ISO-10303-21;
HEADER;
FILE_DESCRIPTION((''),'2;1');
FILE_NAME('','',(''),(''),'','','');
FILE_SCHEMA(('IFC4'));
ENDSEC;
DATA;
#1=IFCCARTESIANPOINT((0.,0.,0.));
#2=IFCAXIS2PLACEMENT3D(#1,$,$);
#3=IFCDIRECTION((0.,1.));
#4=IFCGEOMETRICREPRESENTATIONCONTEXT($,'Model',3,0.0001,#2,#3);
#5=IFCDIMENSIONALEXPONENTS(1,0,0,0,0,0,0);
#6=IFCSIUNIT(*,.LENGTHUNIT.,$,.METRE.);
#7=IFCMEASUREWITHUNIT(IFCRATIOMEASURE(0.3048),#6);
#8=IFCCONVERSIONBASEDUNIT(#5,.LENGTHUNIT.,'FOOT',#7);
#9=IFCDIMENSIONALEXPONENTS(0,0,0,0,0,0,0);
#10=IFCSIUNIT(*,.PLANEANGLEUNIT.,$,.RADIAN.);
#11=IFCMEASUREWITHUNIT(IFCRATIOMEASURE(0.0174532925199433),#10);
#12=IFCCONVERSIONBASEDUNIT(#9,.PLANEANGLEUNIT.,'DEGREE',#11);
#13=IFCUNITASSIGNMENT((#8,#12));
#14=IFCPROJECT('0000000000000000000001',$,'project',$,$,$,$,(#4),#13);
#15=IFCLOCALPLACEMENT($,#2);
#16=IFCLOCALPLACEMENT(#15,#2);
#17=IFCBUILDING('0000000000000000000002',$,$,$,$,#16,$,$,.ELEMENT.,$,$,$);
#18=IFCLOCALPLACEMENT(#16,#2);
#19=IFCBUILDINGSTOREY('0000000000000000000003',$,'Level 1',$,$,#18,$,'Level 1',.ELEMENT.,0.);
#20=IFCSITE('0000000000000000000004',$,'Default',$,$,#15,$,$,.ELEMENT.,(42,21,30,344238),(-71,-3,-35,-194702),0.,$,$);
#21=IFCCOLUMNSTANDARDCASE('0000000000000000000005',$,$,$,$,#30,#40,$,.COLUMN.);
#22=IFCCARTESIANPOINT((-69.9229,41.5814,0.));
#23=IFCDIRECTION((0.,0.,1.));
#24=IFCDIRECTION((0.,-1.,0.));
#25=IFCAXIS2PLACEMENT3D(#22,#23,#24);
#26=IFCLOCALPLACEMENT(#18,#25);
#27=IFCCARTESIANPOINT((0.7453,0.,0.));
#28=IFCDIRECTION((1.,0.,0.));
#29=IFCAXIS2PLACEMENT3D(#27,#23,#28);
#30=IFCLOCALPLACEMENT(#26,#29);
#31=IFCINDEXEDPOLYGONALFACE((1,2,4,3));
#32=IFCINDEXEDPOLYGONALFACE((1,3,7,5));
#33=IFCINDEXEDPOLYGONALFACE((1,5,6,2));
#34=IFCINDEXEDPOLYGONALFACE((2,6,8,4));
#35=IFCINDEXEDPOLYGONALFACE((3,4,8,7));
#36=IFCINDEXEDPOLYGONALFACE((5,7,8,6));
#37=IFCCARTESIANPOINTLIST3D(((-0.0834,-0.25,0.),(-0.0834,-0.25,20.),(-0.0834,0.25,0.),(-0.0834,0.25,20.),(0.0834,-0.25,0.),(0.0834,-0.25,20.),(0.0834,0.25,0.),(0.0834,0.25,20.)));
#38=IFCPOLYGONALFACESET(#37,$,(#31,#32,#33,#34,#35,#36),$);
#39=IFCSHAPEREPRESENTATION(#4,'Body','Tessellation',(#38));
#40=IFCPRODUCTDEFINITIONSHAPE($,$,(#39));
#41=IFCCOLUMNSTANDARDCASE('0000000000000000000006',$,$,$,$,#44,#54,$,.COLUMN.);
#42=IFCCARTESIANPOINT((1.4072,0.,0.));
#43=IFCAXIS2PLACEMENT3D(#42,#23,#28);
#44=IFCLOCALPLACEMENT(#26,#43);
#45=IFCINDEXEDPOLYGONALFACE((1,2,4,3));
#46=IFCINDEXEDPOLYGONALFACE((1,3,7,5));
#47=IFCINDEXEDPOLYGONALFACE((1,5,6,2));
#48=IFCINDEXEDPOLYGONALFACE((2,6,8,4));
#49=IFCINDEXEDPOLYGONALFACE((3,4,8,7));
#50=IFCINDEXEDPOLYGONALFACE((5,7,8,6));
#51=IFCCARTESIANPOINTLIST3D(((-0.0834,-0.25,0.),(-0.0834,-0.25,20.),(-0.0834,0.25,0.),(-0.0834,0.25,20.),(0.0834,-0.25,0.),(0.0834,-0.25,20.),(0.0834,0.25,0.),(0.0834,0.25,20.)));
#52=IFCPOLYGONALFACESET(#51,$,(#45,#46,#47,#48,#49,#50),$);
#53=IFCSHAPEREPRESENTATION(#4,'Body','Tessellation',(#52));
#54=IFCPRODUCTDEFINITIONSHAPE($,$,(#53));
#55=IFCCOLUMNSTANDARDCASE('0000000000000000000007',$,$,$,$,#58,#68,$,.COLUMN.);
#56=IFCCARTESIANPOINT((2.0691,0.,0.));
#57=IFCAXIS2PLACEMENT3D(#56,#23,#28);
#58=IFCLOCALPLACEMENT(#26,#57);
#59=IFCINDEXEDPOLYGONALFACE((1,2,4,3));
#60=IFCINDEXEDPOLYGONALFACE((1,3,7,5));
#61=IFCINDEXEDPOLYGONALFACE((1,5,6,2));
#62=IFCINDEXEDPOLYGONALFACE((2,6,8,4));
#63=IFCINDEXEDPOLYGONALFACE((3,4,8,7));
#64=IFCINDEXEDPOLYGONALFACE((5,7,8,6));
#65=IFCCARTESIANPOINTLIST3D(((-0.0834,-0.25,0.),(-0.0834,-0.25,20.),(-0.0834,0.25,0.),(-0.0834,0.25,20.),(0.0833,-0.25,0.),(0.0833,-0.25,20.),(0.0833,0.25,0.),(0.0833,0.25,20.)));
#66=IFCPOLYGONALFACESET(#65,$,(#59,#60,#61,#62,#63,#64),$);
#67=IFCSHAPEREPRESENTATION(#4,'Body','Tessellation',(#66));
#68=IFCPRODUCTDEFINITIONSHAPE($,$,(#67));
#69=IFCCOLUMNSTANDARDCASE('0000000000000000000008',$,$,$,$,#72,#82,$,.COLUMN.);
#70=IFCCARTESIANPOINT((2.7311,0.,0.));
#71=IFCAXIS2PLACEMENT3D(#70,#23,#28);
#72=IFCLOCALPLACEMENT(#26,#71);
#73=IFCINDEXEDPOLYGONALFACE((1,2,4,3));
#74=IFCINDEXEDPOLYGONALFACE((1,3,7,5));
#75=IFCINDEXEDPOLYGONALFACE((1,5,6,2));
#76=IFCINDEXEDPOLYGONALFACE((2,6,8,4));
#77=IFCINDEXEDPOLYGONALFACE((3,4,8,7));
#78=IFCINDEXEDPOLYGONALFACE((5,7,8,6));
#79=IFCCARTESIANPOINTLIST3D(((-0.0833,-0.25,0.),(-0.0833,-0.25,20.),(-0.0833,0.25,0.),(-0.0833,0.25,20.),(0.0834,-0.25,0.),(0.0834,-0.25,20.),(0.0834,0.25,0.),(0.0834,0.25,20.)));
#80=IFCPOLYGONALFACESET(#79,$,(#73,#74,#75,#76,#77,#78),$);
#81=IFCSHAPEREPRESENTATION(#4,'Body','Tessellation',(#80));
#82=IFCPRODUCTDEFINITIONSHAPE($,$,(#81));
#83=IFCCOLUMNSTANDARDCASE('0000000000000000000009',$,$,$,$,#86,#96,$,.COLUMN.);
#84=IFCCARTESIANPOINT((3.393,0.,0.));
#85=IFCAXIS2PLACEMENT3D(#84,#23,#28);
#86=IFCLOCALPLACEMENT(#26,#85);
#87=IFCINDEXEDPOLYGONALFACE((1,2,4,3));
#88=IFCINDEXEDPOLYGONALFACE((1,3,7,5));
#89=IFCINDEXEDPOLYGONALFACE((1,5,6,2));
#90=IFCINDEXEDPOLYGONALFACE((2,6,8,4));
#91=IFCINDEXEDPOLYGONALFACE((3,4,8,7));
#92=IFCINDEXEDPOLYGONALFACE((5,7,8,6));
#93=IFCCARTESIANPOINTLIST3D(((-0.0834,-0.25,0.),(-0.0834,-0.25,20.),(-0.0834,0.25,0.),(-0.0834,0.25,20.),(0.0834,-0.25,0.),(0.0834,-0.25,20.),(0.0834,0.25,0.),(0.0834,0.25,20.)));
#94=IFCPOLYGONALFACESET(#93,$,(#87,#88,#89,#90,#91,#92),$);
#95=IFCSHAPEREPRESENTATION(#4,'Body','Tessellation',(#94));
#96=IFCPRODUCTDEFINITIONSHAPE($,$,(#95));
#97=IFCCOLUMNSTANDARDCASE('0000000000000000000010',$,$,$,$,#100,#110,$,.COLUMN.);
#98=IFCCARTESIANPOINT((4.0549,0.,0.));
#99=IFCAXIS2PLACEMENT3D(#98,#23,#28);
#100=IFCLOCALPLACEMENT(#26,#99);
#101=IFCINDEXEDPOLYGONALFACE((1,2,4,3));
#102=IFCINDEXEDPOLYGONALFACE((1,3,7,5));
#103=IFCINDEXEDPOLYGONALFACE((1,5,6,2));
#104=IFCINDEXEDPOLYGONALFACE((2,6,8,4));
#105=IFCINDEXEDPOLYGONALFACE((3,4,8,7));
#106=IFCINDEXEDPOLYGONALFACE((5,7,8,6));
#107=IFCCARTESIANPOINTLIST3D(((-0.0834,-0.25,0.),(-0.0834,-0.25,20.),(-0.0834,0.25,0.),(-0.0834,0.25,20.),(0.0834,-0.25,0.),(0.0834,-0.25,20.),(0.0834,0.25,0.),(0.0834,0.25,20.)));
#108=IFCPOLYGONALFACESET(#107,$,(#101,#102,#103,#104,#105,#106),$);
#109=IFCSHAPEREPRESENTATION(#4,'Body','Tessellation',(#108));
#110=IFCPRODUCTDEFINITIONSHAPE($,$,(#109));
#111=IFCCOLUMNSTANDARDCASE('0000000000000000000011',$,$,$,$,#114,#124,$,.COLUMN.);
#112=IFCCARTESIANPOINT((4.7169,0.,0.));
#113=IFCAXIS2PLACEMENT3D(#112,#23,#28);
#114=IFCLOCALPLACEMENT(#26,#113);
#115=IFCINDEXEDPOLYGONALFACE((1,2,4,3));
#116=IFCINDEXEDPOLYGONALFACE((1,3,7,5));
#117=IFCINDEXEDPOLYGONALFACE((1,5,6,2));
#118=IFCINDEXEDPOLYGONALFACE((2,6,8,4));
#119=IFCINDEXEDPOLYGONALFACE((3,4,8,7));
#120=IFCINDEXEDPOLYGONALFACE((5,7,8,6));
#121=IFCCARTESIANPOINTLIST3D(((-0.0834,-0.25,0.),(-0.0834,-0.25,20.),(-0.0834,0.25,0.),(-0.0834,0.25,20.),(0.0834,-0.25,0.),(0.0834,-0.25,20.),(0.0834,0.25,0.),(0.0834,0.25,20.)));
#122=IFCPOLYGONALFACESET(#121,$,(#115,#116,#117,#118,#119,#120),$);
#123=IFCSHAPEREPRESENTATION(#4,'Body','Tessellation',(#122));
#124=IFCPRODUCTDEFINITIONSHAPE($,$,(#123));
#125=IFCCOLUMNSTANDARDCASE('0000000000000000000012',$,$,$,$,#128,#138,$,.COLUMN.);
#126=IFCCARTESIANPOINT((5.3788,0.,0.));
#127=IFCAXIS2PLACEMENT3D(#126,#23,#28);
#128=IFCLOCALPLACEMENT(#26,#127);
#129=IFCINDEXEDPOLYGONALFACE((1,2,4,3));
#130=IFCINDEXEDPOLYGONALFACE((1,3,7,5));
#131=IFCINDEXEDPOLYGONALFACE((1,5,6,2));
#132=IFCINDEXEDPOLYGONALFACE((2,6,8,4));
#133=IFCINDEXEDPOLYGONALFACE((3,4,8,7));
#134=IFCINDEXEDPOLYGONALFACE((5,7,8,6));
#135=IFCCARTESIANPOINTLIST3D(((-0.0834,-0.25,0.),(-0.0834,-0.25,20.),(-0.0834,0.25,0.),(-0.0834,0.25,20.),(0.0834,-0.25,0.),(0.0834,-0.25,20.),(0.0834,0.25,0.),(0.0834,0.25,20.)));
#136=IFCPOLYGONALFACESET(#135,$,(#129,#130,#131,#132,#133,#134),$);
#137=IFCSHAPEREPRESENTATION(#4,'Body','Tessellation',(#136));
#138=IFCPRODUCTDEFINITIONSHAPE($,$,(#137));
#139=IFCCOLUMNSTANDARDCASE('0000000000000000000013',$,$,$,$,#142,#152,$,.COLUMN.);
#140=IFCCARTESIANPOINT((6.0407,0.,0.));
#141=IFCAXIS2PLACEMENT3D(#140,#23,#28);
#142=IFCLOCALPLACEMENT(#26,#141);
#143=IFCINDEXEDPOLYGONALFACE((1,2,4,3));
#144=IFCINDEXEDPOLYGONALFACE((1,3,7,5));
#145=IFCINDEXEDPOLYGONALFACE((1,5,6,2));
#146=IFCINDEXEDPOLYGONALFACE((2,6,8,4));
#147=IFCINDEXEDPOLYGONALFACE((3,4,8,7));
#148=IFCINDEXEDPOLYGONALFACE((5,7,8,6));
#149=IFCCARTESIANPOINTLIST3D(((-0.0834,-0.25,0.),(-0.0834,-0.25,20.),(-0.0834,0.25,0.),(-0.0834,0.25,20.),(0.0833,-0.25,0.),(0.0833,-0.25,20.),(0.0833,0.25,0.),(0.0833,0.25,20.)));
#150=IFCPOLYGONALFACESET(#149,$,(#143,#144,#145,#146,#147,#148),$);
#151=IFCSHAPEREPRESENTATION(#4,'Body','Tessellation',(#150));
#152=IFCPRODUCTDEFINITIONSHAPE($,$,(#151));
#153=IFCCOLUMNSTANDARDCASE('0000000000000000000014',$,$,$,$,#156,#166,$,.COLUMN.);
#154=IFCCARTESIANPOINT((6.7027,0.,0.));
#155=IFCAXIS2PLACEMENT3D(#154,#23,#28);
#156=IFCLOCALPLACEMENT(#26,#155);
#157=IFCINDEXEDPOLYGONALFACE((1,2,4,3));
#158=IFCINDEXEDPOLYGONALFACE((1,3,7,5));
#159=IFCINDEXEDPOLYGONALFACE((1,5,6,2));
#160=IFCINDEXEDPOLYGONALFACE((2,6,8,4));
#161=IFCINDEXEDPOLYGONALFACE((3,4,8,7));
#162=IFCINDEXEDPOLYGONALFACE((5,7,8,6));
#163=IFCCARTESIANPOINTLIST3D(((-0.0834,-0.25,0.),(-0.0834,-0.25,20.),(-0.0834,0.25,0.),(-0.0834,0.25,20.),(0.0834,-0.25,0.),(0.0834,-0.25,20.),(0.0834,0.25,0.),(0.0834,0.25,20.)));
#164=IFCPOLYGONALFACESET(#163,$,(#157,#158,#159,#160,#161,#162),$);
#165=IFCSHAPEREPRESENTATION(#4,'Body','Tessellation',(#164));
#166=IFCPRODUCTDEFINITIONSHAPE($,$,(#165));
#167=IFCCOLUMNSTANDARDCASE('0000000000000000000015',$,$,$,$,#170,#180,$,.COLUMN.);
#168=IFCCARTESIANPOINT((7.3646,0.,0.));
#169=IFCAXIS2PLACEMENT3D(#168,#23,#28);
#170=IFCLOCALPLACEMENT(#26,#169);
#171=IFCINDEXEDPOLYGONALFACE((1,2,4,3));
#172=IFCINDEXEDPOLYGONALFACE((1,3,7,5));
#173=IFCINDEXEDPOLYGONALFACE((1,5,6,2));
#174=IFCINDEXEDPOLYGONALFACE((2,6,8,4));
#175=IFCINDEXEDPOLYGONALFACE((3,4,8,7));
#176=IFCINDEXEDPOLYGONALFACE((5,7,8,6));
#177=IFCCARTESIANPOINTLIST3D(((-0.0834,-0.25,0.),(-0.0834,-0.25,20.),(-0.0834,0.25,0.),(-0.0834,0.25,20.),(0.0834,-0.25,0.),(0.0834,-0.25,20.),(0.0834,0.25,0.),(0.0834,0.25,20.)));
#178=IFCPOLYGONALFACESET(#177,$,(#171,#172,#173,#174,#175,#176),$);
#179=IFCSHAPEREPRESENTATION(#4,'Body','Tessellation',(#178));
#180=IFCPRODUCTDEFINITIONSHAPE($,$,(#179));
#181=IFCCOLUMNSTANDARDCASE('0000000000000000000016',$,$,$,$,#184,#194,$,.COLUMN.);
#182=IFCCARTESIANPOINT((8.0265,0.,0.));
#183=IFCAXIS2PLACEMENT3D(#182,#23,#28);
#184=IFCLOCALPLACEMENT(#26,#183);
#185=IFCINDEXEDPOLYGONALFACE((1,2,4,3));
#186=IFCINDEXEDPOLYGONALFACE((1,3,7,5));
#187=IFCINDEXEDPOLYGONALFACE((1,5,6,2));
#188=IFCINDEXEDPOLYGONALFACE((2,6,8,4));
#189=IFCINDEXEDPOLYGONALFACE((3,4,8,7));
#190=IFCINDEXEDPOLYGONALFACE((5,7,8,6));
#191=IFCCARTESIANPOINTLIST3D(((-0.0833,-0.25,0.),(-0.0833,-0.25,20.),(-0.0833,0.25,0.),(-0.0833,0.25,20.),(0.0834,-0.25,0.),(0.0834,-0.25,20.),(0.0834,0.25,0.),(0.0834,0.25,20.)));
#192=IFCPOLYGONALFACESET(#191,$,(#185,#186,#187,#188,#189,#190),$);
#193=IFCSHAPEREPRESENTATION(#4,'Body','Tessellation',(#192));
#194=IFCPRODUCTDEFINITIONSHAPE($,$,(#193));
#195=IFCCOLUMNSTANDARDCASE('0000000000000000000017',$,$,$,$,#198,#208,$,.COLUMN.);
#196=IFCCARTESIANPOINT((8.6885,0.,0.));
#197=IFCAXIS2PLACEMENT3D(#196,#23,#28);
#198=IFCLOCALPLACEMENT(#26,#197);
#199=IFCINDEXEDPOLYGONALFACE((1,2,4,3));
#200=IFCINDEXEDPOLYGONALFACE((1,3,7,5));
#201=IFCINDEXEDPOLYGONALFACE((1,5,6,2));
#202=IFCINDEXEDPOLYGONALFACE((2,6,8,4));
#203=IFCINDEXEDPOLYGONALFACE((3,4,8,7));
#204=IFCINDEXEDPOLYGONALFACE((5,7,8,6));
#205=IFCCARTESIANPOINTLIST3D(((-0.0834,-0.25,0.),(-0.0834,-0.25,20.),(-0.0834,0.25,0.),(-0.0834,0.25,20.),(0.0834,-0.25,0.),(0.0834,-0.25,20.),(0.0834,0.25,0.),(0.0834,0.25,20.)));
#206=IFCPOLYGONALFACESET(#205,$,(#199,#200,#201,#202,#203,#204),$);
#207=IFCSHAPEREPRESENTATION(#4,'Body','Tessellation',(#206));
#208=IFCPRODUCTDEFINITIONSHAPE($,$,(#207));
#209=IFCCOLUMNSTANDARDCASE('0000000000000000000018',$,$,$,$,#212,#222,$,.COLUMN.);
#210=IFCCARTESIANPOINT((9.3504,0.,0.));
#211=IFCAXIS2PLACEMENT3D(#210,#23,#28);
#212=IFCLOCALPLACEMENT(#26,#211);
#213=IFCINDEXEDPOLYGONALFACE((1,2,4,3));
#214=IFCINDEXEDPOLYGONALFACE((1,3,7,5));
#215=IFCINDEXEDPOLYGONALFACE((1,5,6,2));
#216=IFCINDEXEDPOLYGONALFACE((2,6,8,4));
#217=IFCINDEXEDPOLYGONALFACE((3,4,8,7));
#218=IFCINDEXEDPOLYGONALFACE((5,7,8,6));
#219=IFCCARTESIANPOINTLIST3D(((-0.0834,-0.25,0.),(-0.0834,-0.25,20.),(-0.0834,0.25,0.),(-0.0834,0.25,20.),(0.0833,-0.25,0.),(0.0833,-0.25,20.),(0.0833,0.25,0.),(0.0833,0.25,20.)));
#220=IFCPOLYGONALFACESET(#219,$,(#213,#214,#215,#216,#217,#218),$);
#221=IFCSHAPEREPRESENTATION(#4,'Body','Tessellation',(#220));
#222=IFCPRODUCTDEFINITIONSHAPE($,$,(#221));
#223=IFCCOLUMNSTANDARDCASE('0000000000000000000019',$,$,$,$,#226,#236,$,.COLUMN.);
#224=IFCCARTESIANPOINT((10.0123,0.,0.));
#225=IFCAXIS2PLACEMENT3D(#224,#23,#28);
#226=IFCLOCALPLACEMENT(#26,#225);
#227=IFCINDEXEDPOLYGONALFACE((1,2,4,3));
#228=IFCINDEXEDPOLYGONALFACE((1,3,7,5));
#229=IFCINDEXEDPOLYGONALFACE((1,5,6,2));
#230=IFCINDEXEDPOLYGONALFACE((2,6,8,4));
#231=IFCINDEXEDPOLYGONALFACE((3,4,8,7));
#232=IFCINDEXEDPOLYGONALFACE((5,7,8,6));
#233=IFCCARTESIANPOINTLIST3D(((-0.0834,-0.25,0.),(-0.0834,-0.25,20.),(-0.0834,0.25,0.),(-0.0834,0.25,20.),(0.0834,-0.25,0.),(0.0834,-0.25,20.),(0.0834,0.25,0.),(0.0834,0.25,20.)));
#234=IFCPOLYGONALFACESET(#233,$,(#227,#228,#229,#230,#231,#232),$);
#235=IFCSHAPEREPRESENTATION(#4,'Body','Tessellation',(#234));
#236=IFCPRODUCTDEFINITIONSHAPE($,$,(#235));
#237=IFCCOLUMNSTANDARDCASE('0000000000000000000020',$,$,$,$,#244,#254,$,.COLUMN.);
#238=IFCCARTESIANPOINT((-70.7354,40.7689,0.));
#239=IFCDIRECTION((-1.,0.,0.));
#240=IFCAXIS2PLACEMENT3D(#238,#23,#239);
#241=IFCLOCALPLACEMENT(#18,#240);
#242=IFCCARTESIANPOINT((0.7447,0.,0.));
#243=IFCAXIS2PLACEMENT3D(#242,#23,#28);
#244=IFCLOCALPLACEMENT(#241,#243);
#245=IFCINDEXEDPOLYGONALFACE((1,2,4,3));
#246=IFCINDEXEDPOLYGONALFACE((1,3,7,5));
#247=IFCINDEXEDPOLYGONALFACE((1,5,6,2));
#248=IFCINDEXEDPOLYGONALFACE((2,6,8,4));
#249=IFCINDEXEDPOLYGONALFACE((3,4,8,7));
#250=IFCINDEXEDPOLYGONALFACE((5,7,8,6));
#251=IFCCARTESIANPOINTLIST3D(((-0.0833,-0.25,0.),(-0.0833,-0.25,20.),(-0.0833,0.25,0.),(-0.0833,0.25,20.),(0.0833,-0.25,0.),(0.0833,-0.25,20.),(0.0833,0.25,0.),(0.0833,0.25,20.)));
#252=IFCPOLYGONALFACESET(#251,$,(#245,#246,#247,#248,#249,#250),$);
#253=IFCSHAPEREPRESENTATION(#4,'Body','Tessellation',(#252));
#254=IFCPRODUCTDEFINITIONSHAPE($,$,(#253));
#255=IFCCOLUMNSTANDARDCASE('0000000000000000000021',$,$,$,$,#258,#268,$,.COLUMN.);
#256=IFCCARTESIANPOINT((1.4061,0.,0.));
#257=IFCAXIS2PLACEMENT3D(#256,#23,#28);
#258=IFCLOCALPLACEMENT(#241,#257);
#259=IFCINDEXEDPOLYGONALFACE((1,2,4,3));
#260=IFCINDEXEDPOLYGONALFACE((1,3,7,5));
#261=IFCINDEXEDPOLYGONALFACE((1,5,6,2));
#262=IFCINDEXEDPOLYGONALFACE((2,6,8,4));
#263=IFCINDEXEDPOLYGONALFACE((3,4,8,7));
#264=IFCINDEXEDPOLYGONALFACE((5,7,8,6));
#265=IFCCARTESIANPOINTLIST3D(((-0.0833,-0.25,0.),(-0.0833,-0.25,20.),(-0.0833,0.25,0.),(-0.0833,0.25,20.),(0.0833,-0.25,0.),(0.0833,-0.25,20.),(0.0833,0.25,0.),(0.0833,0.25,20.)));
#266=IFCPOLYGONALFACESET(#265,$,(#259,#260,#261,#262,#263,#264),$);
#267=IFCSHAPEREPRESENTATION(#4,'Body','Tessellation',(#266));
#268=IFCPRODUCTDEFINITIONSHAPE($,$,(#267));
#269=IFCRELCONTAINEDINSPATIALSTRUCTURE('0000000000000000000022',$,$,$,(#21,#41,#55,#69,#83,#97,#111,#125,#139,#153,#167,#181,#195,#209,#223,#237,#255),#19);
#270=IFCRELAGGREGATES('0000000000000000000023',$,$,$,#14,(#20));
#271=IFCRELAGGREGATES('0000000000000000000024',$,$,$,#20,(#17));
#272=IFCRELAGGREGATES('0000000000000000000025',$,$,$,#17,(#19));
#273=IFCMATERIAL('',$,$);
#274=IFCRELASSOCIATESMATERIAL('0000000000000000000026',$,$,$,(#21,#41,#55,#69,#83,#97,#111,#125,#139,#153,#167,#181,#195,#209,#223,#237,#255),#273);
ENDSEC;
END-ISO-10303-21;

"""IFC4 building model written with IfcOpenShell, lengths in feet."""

from ifc_helpers import new_model, entity, si_unit, converted_unit, direction, frame, origin, place, context, project, spatial, rectangle, extrude, material, element, save


model = new_model("IFC4")

# Units and contexts
model_context = context("Model", 3, precision=0.0001, world=origin(), true_north=direction((0.0, 1.0)))
ifc_project = project(units=[converted_unit("LENGTHUNIT", "FOOT", entity("IfcRatioMeasure", 0.3048), si_unit("LENGTHUNIT", "METRE"), dimensions=[1, 0, 0, 0, 0, 0, 0]), converted_unit("PLANEANGLEUNIT", "DEGREE", entity("IfcRatioMeasure", 0.0174532925199433), si_unit("PLANEANGLEUNIT", "RADIAN"), dimensions=[0, 0, 0, 0, 0, 0, 0])], contexts=[model_context])

# Site, building, storey
site_placement = place(None, origin())
site = spatial("IfcSite", under=ifc_project, at=site_placement, Name="Default", CompositionType="ELEMENT", RefLatitude=(42, 21, 30, 344238), RefLongitude=(-71, -3, -35, -194702), RefElevation=0.0)
building_placement = place(site_placement, origin())
building = spatial("IfcBuilding", under=site, at=building_placement, CompositionType="ELEMENT")
storey_placement = place(building_placement, origin())
storey = spatial("IfcBuildingStorey", under=building, at=storey_placement, Name="Level 1", LongName="Level 1", CompositionType="ELEMENT", Elevation=0.0)

# Columns
ifc_material_1 = material(Name="")
wall_1_placement = place(storey_placement, frame((-69.9229, 41.5814, 0.0), z_axis=(0.0, 0.0, 1.0), x_axis=(0.0, -1.0, 0.0)))
for number, where, z_axis, x_axis in (
    (1, (0.7453, 0.0, 0.0), (0.0, 0.0, 1.0), (1.0, 0.0, 0.0)),
    (2, (1.4072, 0.0, 0.0), (0.0, 0.0, 1.0), (1.0, 0.0, 0.0)),
    (3, (2.0691, 0.0, 0.0), (0.0, 0.0, 1.0), (1.0, 0.0, 0.0)),
    (4, (2.7311, 0.0, 0.0), (0.0, 0.0, 1.0), (1.0, 0.0, 0.0)),
    (5, (3.393, 0.0, 0.0), (0.0, 0.0, 1.0), (1.0, 0.0, 0.0)),
    (6, (4.0549, 0.0, 0.0), (0.0, 0.0, 1.0), (1.0, 0.0, 0.0)),
    (7, (4.7169, 0.0, 0.0), (0.0, 0.0, 1.0), (1.0, 0.0, 0.0)),
    (8, (5.3788, 0.0, 0.0), (0.0, 0.0, 1.0), (1.0, 0.0, 0.0)),
    (9, (6.0407, 0.0, 0.0), (0.0, 0.0, 1.0), (1.0, 0.0, 0.0)),
    (10, (6.7027, 0.0, 0.0), (0.0, 0.0, 1.0), (1.0, 0.0, 0.0)),
    (11, (7.3646, 0.0, 0.0), (0.0, 0.0, 1.0), (1.0, 0.0, 0.0)),
    (12, (8.0265, 0.0, 0.0), (0.0, 0.0, 1.0), (1.0, 0.0, 0.0)),
    (13, (8.6885, 0.0, 0.0), (0.0, 0.0, 1.0), (1.0, 0.0, 0.0)),
    (14, (9.3504, 0.0, 0.0), (0.0, 0.0, 1.0), (1.0, 0.0, 0.0)),
    (15, (10.0123, 0.0, 0.0), (0.0, 0.0, 1.0), (1.0, 0.0, 0.0)),
):
    element("IfcColumnStandardCase", number, at=place(wall_1_placement, frame(where, z_axis=z_axis, x_axis=x_axis)), inside=storey, material=ifc_material_1, PredefinedType="COLUMN", context=model_context, shape_type="SweptSolid", body=[
        extrude(rectangle(XDim=0.1667, YDim=0.5), origin(), (0.0, 0.0, 1.0), 20.0),
    ])
wall_2_placement = place(storey_placement, frame((-70.7354, 40.7689, 0.0), z_axis=(0.0, 0.0, 1.0), x_axis=(-1.0, 0.0, 0.0)))
for number, where, z_axis, x_axis in (
    (16, (0.7447, 0.0, 0.0), (0.0, 0.0, 1.0), (1.0, 0.0, 0.0)),
    (17, (1.4061, 0.0, 0.0), (0.0, 0.0, 1.0), (1.0, 0.0, 0.0)),
):
    element("IfcColumnStandardCase", number, at=place(wall_2_placement, frame(where, z_axis=z_axis, x_axis=x_axis)), inside=storey, material=ifc_material_1, PredefinedType="COLUMN", context=model_context, shape_type="SweptSolid", body=[
        extrude(rectangle(XDim=0.1667, YDim=0.5), origin(), (0.0, 0.0, 1.0), 20.0),
    ])

save(model, "model.ifc")
